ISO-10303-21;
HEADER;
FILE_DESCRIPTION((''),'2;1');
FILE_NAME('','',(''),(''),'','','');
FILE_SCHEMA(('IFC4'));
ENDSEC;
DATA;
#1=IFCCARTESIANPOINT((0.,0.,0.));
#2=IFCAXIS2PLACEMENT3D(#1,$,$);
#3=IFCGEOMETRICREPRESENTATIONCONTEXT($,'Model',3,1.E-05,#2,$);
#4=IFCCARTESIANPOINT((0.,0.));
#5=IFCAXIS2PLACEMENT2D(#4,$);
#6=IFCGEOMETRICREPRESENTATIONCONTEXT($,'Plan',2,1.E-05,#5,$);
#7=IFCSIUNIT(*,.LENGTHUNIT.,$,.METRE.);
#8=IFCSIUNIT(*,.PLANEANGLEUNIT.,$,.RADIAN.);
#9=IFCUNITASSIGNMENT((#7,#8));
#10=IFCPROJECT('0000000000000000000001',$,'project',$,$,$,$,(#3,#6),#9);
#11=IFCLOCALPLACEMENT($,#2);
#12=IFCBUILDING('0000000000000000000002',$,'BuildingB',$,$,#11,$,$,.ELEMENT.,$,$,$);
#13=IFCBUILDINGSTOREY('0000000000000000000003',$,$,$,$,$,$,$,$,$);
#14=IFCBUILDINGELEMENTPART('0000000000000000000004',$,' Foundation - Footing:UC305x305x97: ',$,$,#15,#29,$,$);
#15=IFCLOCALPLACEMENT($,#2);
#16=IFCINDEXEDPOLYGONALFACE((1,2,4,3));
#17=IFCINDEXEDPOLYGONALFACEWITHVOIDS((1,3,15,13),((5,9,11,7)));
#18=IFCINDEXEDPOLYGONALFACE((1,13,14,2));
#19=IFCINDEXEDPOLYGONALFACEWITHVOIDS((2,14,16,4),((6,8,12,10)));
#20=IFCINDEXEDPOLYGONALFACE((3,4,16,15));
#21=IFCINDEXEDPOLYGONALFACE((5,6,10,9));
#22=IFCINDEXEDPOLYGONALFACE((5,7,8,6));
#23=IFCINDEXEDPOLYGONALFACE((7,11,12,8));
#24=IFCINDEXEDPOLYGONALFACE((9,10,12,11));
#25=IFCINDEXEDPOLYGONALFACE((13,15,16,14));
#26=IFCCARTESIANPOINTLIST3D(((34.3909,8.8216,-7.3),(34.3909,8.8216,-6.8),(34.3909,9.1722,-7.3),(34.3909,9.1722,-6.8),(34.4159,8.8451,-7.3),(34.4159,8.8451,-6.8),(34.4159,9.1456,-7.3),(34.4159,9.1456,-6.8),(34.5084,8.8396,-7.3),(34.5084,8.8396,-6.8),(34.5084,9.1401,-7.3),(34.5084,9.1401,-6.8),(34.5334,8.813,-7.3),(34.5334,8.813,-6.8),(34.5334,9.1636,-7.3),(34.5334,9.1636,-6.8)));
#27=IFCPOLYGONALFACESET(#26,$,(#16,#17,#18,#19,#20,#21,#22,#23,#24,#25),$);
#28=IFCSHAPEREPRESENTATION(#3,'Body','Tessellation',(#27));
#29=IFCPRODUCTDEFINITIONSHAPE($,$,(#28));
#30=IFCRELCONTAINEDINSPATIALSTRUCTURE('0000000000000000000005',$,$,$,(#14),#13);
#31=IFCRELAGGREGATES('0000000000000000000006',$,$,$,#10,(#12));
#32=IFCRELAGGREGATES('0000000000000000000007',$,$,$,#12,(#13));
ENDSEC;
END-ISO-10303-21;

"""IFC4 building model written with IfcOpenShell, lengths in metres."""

from ifc_helpers import new_model, si_unit, origin, origin_2d, place, context, project, spatial, polyline, outline, extrude, element, save


model = new_model("IFC4")

# Units and contexts
model_context = context("Model", 3, precision=1e-05, world=origin())
plan_context = context("Plan", 2, precision=1e-05, world=origin_2d())
ifc_project = project(units=[si_unit("LENGTHUNIT", "METRE"), si_unit("PLANEANGLEUNIT", "RADIAN")], contexts=[model_context, plan_context])

# Building, storey
building_placement = place(None, origin())
building = spatial("IfcBuilding", under=ifc_project, at=building_placement, Name="BuildingB", CompositionType="ELEMENT")
storey = spatial("IfcBuildingStorey", under=building)

# Building element part, opening
building_element_part_1 = element("IfcBuildingElementPart", 1, inside=storey, Name=" Foundation - Footing:UC305x305x97: ", context=model_context, shape_type="SweptSolid", body=[
    extrude(outline(polyline([(34.3909, 8.8216, -7.3), (34.5334, 8.813, -7.3), (34.5334, 9.1636, -7.3), (34.3909, 9.1722, -7.3), (34.3909, 8.8216, -7.3)])), None, (0.0, 0.0, 1.0), 0.5),
])
element("IfcOpeningElement", 2, inside=storey, cuts=building_element_part_1, context=model_context, shape_type="SweptSolid", body=[
    extrude(outline(polyline([(34.4159, 8.8451, -7.3), (34.5084, 8.8396, -7.3), (34.5084, 9.1401, -7.3), (34.4159, 9.1456, -7.3), (34.4159, 8.8451, -7.3)])), None, (0.0, 0.0, 1.0), 0.5),
])

save(model, "model.ifc")
